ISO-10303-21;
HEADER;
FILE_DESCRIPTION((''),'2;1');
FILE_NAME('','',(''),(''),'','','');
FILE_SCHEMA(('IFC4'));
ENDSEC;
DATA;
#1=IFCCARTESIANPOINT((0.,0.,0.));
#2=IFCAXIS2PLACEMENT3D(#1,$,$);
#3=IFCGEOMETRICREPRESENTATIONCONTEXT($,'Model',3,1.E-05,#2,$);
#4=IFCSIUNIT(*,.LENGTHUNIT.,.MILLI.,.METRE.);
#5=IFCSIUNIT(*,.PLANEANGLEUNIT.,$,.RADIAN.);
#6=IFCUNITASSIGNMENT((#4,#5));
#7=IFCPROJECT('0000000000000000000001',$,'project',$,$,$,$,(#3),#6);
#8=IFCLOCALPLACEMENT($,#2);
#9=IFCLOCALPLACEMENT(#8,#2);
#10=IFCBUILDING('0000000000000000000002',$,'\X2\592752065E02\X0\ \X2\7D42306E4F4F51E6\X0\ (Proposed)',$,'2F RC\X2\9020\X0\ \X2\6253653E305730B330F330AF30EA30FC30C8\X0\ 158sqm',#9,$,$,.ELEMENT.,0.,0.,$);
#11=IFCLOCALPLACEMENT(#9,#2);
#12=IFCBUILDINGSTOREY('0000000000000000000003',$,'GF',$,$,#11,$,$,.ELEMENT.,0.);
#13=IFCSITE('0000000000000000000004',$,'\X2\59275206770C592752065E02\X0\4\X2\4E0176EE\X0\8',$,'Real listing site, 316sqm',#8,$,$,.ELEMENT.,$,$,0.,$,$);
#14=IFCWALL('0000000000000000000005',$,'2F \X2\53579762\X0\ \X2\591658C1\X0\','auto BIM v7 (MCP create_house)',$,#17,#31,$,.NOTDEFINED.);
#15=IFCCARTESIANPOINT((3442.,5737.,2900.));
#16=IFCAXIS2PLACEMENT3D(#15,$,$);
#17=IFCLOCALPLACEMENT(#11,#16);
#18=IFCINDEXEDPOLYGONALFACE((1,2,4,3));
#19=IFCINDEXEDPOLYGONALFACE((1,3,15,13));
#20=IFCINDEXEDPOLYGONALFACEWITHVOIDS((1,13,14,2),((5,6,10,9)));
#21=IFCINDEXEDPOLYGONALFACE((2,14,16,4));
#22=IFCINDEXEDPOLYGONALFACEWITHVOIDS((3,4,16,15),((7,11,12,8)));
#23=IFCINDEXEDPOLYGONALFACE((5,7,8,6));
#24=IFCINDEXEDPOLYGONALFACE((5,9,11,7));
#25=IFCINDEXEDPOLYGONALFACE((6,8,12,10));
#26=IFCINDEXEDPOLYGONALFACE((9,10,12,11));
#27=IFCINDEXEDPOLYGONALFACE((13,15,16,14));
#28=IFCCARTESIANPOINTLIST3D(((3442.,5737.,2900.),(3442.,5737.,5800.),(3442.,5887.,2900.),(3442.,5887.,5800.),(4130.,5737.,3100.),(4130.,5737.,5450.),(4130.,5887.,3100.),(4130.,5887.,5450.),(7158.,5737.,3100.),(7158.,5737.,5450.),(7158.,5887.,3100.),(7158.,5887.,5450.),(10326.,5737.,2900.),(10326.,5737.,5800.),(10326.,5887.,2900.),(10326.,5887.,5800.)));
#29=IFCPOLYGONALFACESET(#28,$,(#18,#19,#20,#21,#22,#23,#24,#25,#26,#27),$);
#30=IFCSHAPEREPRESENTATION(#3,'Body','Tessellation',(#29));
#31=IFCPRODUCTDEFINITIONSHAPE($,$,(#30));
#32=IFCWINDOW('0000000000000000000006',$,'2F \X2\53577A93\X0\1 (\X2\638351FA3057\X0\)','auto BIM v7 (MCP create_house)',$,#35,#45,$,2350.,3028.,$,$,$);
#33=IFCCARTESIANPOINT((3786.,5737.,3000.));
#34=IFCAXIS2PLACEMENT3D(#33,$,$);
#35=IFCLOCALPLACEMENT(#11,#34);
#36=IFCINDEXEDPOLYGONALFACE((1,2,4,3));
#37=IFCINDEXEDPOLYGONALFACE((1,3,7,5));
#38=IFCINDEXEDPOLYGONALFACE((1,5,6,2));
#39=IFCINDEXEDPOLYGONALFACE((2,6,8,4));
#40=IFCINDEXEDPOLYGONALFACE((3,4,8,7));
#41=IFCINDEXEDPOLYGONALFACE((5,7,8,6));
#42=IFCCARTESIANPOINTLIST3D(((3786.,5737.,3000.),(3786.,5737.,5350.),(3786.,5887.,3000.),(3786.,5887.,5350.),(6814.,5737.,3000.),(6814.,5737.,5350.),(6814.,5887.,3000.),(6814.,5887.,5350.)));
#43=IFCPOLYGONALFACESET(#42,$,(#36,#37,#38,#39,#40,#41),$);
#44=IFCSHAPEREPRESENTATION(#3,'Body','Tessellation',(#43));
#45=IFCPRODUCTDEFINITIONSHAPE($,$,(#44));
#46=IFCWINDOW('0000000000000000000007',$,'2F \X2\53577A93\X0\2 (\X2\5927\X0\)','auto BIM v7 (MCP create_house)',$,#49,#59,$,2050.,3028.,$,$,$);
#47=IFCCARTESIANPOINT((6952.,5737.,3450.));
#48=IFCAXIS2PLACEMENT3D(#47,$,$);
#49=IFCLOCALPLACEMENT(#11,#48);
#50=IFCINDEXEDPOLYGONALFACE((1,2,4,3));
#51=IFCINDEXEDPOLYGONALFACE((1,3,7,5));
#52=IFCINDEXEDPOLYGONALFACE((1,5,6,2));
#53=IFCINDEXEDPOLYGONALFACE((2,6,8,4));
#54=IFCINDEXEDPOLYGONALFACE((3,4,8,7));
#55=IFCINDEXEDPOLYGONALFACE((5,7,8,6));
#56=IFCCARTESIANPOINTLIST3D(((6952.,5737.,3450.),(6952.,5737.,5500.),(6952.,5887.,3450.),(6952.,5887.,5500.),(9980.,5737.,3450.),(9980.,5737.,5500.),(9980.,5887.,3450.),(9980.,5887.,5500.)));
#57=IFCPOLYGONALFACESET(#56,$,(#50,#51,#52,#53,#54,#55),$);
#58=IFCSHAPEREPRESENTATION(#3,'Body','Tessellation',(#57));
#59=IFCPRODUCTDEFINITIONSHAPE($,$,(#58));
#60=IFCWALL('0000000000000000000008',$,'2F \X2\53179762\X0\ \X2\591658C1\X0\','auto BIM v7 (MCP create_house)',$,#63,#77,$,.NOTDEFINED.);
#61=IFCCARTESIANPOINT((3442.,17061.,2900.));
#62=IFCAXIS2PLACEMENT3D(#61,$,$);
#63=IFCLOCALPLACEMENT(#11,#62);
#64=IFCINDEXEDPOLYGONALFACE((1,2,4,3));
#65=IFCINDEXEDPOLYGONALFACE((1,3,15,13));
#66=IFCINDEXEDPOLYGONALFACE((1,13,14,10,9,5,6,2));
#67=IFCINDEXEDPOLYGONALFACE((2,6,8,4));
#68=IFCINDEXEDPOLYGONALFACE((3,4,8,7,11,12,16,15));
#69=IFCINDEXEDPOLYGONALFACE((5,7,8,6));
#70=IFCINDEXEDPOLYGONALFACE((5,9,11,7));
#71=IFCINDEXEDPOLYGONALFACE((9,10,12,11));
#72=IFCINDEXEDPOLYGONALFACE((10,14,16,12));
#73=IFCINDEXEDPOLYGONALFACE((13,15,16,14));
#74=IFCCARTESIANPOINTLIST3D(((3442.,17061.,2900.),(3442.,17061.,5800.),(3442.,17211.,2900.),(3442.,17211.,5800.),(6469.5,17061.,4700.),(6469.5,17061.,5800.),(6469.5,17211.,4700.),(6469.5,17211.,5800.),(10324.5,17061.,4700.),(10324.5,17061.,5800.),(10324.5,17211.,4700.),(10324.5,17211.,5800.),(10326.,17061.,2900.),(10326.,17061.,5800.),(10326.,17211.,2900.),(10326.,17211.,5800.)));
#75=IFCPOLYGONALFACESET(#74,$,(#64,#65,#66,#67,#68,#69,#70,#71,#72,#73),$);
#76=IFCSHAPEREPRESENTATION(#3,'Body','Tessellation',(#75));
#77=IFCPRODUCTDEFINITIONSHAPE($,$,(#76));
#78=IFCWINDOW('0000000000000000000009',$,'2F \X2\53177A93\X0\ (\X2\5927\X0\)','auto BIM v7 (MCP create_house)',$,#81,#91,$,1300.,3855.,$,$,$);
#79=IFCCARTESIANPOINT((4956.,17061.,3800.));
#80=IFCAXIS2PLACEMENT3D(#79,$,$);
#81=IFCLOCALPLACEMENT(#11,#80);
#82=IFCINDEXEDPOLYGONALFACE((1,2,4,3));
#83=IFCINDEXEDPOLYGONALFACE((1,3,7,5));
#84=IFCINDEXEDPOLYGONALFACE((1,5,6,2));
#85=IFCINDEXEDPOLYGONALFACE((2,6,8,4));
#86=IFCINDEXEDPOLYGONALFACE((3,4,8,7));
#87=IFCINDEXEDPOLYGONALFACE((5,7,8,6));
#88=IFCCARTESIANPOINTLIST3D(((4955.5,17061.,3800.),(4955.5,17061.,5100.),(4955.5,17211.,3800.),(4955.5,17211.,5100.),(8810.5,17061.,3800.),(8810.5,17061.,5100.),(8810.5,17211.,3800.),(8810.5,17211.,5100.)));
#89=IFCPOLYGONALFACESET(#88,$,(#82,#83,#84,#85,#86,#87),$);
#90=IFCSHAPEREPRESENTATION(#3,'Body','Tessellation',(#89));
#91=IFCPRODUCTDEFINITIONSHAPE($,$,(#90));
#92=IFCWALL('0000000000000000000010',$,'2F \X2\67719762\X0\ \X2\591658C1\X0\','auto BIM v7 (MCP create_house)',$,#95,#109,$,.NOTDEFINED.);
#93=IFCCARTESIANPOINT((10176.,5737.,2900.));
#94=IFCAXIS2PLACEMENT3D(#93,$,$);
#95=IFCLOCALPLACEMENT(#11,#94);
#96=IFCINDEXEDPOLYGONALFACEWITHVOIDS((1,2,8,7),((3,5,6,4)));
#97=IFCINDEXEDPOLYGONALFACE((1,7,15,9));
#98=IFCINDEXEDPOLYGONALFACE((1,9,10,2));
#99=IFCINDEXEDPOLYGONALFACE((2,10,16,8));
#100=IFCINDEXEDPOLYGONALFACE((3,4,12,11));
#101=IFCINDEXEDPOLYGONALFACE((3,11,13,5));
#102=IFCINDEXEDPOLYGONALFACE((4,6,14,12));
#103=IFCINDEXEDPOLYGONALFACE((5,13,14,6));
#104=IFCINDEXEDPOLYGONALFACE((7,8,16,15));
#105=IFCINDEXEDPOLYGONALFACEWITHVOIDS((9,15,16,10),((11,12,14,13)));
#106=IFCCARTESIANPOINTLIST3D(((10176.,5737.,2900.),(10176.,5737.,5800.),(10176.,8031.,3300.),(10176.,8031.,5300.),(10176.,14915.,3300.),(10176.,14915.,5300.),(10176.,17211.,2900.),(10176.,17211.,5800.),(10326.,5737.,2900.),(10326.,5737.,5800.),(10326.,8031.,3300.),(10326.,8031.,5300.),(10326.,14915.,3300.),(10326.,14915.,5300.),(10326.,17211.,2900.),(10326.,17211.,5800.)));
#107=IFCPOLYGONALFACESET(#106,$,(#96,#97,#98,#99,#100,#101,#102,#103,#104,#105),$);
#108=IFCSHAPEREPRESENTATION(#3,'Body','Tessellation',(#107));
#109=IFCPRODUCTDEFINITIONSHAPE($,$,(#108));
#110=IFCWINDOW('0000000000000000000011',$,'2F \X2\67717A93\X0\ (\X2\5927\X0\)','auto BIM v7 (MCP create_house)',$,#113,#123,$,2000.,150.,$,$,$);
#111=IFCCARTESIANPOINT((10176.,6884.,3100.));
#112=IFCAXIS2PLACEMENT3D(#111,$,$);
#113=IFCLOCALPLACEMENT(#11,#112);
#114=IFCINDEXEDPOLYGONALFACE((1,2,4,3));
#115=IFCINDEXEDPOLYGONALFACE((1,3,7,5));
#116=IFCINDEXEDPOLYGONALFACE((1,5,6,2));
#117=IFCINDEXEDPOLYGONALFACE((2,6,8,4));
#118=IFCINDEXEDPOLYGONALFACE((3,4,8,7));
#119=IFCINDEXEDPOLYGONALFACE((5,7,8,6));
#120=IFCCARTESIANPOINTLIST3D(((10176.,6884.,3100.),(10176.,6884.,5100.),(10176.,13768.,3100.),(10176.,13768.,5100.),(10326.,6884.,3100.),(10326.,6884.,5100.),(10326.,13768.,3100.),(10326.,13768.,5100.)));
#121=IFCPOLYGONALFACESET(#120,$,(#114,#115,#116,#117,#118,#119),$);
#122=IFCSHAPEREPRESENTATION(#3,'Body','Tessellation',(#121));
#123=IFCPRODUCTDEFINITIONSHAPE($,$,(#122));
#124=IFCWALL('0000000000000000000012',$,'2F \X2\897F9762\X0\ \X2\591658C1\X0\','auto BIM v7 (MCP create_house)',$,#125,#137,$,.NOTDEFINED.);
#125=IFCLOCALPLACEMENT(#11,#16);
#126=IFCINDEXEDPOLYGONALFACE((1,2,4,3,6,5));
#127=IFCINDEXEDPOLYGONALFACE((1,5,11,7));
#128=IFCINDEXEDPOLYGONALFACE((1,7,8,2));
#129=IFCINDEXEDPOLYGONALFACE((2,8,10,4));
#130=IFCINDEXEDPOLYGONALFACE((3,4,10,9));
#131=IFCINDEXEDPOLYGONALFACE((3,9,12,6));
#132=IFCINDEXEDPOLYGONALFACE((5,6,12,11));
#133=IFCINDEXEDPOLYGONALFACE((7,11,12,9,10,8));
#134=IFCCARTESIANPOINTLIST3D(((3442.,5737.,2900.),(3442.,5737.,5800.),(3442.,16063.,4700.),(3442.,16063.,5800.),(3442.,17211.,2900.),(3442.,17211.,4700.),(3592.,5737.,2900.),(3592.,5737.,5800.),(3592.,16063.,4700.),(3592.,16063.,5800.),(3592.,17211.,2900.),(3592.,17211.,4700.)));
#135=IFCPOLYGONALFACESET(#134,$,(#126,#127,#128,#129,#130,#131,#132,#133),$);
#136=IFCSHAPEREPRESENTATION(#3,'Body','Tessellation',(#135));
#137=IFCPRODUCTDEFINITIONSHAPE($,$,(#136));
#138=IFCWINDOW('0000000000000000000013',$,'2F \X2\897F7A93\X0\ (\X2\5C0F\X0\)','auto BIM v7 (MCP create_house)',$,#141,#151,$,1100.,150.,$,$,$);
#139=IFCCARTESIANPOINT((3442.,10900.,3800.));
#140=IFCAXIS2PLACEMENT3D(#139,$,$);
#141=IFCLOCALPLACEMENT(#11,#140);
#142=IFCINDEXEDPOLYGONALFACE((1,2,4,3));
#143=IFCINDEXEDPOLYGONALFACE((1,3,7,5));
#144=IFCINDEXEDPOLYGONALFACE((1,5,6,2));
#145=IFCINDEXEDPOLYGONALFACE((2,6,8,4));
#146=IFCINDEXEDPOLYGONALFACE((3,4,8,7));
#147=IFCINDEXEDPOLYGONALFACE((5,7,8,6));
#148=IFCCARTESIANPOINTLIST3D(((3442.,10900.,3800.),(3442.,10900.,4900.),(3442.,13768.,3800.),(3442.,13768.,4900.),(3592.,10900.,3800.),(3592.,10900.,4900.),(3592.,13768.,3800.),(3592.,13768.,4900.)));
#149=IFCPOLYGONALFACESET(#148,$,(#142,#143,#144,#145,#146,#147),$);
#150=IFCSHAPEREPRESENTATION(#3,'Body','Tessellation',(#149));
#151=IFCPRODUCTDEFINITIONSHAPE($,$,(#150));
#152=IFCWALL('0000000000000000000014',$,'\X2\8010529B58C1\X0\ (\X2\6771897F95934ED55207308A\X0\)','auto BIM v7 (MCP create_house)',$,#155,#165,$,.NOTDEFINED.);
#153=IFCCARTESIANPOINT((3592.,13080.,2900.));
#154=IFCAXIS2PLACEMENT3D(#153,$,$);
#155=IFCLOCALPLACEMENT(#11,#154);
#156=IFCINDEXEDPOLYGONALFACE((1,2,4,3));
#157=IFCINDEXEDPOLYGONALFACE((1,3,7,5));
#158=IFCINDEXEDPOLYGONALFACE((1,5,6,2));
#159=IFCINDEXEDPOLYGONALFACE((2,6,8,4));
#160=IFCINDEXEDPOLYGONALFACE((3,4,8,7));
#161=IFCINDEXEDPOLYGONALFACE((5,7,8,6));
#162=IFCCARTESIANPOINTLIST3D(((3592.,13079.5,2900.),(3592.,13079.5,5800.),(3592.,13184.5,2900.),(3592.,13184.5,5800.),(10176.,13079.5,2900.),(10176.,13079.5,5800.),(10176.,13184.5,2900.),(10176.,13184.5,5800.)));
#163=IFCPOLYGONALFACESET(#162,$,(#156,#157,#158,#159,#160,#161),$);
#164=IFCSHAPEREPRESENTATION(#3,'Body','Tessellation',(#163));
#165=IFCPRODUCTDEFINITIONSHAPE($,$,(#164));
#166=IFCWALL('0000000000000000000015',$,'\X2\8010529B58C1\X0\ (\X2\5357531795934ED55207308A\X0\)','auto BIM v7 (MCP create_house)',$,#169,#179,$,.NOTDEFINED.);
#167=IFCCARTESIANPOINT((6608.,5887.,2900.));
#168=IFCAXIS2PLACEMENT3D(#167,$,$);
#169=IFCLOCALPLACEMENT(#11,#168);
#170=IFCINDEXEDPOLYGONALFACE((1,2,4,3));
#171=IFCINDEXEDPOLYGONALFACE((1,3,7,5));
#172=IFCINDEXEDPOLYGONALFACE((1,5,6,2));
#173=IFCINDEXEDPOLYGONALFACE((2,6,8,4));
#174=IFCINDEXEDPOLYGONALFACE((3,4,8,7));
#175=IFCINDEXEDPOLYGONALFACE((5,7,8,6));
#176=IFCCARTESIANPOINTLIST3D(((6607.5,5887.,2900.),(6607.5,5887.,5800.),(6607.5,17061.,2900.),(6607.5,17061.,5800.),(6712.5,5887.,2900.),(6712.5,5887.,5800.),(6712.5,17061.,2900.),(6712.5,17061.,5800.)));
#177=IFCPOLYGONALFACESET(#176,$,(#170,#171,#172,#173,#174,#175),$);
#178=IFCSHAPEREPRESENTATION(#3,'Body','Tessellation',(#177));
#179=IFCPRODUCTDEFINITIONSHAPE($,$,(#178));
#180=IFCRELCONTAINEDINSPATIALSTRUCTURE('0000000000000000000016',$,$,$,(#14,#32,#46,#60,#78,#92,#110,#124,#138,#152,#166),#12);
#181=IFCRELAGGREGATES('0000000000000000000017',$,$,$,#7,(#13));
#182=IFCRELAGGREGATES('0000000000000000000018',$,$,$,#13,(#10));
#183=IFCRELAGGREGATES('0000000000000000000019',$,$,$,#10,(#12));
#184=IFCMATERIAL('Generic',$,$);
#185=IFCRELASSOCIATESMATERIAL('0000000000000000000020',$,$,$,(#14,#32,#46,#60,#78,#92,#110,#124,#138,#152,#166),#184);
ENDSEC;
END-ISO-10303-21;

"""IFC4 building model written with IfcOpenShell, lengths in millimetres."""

from ifc_helpers import new_model, si_unit, frame, frame_2d, origin, place, context, project, spatial, rectangle, extrude, material, element, fill, save


model = new_model("IFC4")

# Units and contexts
model_context = context("Model", 3, precision=1e-05, world=origin())
ifc_project = project(units=[si_unit("LENGTHUNIT", "METRE", prefix="MILLI"), si_unit("PLANEANGLEUNIT", "RADIAN")], contexts=[model_context])

# Site, building, storey
site_placement = place(None, origin())
site = spatial("IfcSite", under=ifc_project, at=site_placement, Name="大分県大分市4丁目8", ObjectType="Real listing site, 316sqm", CompositionType="ELEMENT", RefElevation=0.0)
building_placement = place(site_placement, origin())
building = spatial("IfcBuilding", under=site, at=building_placement, Name="大分市 終の住処 (Proposed)", ObjectType="2F RC造 打放しコンクリート 158sqm", CompositionType="ELEMENT", ElevationOfRefHeight=0.0, ElevationOfTerrain=0.0)
storey_placement = place(building_placement, origin())
storey = spatial("IfcBuildingStorey", under=building, at=storey_placement, Name="GF", CompositionType="ELEMENT", Elevation=0.0)

# Shared definitions
ifc_material = material(Name="Generic")

# Wall, openings, windows
wall_1_placement = place(storey_placement, frame((3442.0, 5737.0, 2900.0)))
wall_1 = element("IfcWall", 1, at=wall_1_placement, inside=storey, material=ifc_material, Name="2F 南面 外壁", Description="auto BIM v7 (MCP create_house)", PredefinedType="NOTDEFINED", context=model_context, shape_type="SweptSolid", body=[
    extrude(rectangle(XDim=6884.0, YDim=150.0, at=frame_2d((3442.0, 75.0))), frame((3442.0, 5737.0, 2900.0)), (0.0, 0.0, 1.0), 2900.0),
])
opening_1_placement = place(storey_placement, frame((3786.0, 5737.0, 3000.0)))
opening_1 = element("IfcOpeningElement", 2, at=opening_1_placement, cuts=wall_1, PredefinedType="NOTDEFINED", context=model_context, shape_type="SweptSolid", body=[
    extrude(rectangle(XDim=3028.0, YDim=150.0, at=frame_2d((1514.0, 75.0))), frame((3786.0, 5737.0, 3000.0)), (0.0, 0.0, 1.0), 2350.0),
])
opening_2_placement = place(storey_placement, frame((6952.0, 5737.0, 3450.0)))
opening_2 = element("IfcOpeningElement", 3, at=opening_2_placement, cuts=wall_1, PredefinedType="NOTDEFINED", context=model_context, shape_type="SweptSolid", body=[
    extrude(rectangle(XDim=3028.0, YDim=150.0, at=frame_2d((1514.0, 75.0))), frame((6952.0, 5737.0, 3450.0)), (0.0, 0.0, 1.0), 2050.0),
])
window_1_placement = place(storey_placement, frame((3786.0, 5737.0, 3000.0)))
window_1 = element("IfcWindow", 4, at=window_1_placement, inside=storey, material=ifc_material, Name="2F 南窓1 (掃出し)", Description="auto BIM v7 (MCP create_house)", OverallHeight=2350.0, OverallWidth=3028.0, context=model_context, shape_type="SweptSolid", body=[
    extrude(rectangle(XDim=3028.0, YDim=150.0, at=frame_2d((1514.0, 75.0))), frame((3786.0, 5737.0, 3000.0)), (0.0, 0.0, 1.0), 2350.0),
])
fill(opening_1, window_1)
window_2_placement = place(storey_placement, frame((6952.0, 5737.0, 3450.0)))
window_2 = element("IfcWindow", 5, at=window_2_placement, inside=storey, material=ifc_material, Name="2F 南窓2 (大)", Description="auto BIM v7 (MCP create_house)", OverallHeight=2050.0, OverallWidth=3028.0, context=model_context, shape_type="SweptSolid", body=[
    extrude(rectangle(XDim=3028.0, YDim=150.0, at=frame_2d((1514.0, 75.0))), frame((6952.0, 5737.0, 3450.0)), (0.0, 0.0, 1.0), 2050.0),
])
fill(opening_2, window_2)

# Walls, openings, windows
wall_2_placement = place(storey_placement, frame((3442.0, 17061.0, 2900.0)))
wall_2 = element("IfcWall", 6, at=wall_2_placement, inside=storey, material=ifc_material, Name="2F 北面 外壁", Description="auto BIM v7 (MCP create_house)", PredefinedType="NOTDEFINED", context=model_context, shape_type="SweptSolid", body=[
    extrude(rectangle(XDim=6884.0, YDim=150.0, at=frame_2d((3442.0, 75.0))), frame((3442.0, 17061.0, 2900.0)), (0.0, 0.0, 1.0), 2900.0),
])
opening_3_placement = place(storey_placement, frame((4956.0, 17061.0, 3800.0)))
opening_3 = element("IfcOpeningElement", 7, at=opening_3_placement, cuts=wall_2, PredefinedType="NOTDEFINED", context=model_context, shape_type="SweptSolid", body=[
    extrude(rectangle(XDim=3855.0, YDim=150.0, at=frame_2d((1927.0, 75.0))), frame((4956.0, 17061.0, 3800.0)), (0.0, 0.0, 1.0), 1300.0),
])
window_3_placement = place(storey_placement, frame((4956.0, 17061.0, 3800.0)))
window_3 = element("IfcWindow", 8, at=window_3_placement, inside=storey, material=ifc_material, Name="2F 北窓 (大)", Description="auto BIM v7 (MCP create_house)", OverallHeight=1300.0, OverallWidth=3855.0, context=model_context, shape_type="SweptSolid", body=[
    extrude(rectangle(XDim=3855.0, YDim=150.0, at=frame_2d((1927.0, 75.0))), frame((4956.0, 17061.0, 3800.0)), (0.0, 0.0, 1.0), 1300.0),
])
fill(opening_3, window_3)
wall_3_placement = place(storey_placement, frame((10176.0, 5737.0, 2900.0)))
wall_3 = element("IfcWall", 9, at=wall_3_placement, inside=storey, material=ifc_material, Name="2F 東面 外壁", Description="auto BIM v7 (MCP create_house)", PredefinedType="NOTDEFINED", context=model_context, shape_type="SweptSolid", body=[
    extrude(rectangle(XDim=150.0, YDim=11474.0, at=frame_2d((75.0, 5737.0))), frame((10176.0, 5737.0, 2900.0)), (0.0, 0.0, 1.0), 2900.0),
])
opening_4_placement = place(storey_placement, frame((10176.0, 6884.0, 3100.0)))
opening_4 = element("IfcOpeningElement", 10, at=opening_4_placement, cuts=wall_3, PredefinedType="NOTDEFINED", context=model_context, shape_type="SweptSolid", body=[
    extrude(rectangle(XDim=150.0, YDim=6884.0, at=frame_2d((75.0, 3442.0))), frame((10176.0, 6884.0, 3100.0)), (0.0, 0.0, 1.0), 2000.0),
])
window_4_placement = place(storey_placement, frame((10176.0, 6884.0, 3100.0)))
window_4 = element("IfcWindow", 11, at=window_4_placement, inside=storey, material=ifc_material, Name="2F 東窓 (大)", Description="auto BIM v7 (MCP create_house)", OverallHeight=2000.0, OverallWidth=150.0, context=model_context, shape_type="SweptSolid", body=[
    extrude(rectangle(XDim=150.0, YDim=6884.0, at=frame_2d((75.0, 3442.0))), frame((10176.0, 6884.0, 3100.0)), (0.0, 0.0, 1.0), 2000.0),
])
fill(opening_4, window_4)
wall_4_placement = place(storey_placement, frame((3442.0, 5737.0, 2900.0)))
wall_4 = element("IfcWall", 12, at=wall_4_placement, inside=storey, material=ifc_material, Name="2F 西面 外壁", Description="auto BIM v7 (MCP create_house)", PredefinedType="NOTDEFINED", context=model_context, shape_type="SweptSolid", body=[
    extrude(rectangle(XDim=150.0, YDim=11474.0, at=frame_2d((75.0, 5737.0))), frame((3442.0, 5737.0, 2900.0)), (0.0, 0.0, 1.0), 2900.0),
])
opening_5_placement = place(storey_placement, frame((3442.0, 10900.0, 3800.0)))
opening_5 = element("IfcOpeningElement", 13, at=opening_5_placement, cuts=wall_4, PredefinedType="NOTDEFINED", context=model_context, shape_type="SweptSolid", body=[
    extrude(rectangle(XDim=150.0, YDim=2868.0, at=frame_2d((75.0, 1434.0))), frame((3442.0, 10900.0, 3800.0)), (0.0, 0.0, 1.0), 1100.0),
])
window_5_placement = place(storey_placement, frame((3442.0, 10900.0, 3800.0)))
window_5 = element("IfcWindow", 14, at=window_5_placement, inside=storey, material=ifc_material, Name="2F 西窓 (小)", Description="auto BIM v7 (MCP create_house)", OverallHeight=1100.0, OverallWidth=150.0, context=model_context, shape_type="SweptSolid", body=[
    extrude(rectangle(XDim=150.0, YDim=2868.0, at=frame_2d((75.0, 1434.0))), frame((3442.0, 10900.0, 3800.0)), (0.0, 0.0, 1.0), 1100.0),
])
fill(opening_5, window_5)

# Walls
wall_5_placement = place(storey_placement, frame((3592.0, 13080.0, 2900.0)))
element("IfcWall", 15, at=wall_5_placement, inside=storey, material=ifc_material, Name="耐力壁 (東西間仕切り)", Description="auto BIM v7 (MCP create_house)", PredefinedType="NOTDEFINED", context=model_context, shape_type="SweptSolid", body=[
    extrude(rectangle(XDim=6584.0, YDim=105.0, at=frame_2d((3292.0, 52.0))), frame((3592.0, 13080.0, 2900.0)), (0.0, 0.0, 1.0), 2900.0),
])
wall_6_placement = place(storey_placement, frame((6608.0, 5887.0, 2900.0)))
element("IfcWall", 16, at=wall_6_placement, inside=storey, material=ifc_material, Name="耐力壁 (南北間仕切り)", Description="auto BIM v7 (MCP create_house)", PredefinedType="NOTDEFINED", context=model_context, shape_type="SweptSolid", body=[
    extrude(rectangle(XDim=105.0, YDim=11174.0, at=frame_2d((52.0, 5587.0))), frame((6608.0, 5887.0, 2900.0)), (0.0, 0.0, 1.0), 2900.0),
])

save(model, "model.ifc")
